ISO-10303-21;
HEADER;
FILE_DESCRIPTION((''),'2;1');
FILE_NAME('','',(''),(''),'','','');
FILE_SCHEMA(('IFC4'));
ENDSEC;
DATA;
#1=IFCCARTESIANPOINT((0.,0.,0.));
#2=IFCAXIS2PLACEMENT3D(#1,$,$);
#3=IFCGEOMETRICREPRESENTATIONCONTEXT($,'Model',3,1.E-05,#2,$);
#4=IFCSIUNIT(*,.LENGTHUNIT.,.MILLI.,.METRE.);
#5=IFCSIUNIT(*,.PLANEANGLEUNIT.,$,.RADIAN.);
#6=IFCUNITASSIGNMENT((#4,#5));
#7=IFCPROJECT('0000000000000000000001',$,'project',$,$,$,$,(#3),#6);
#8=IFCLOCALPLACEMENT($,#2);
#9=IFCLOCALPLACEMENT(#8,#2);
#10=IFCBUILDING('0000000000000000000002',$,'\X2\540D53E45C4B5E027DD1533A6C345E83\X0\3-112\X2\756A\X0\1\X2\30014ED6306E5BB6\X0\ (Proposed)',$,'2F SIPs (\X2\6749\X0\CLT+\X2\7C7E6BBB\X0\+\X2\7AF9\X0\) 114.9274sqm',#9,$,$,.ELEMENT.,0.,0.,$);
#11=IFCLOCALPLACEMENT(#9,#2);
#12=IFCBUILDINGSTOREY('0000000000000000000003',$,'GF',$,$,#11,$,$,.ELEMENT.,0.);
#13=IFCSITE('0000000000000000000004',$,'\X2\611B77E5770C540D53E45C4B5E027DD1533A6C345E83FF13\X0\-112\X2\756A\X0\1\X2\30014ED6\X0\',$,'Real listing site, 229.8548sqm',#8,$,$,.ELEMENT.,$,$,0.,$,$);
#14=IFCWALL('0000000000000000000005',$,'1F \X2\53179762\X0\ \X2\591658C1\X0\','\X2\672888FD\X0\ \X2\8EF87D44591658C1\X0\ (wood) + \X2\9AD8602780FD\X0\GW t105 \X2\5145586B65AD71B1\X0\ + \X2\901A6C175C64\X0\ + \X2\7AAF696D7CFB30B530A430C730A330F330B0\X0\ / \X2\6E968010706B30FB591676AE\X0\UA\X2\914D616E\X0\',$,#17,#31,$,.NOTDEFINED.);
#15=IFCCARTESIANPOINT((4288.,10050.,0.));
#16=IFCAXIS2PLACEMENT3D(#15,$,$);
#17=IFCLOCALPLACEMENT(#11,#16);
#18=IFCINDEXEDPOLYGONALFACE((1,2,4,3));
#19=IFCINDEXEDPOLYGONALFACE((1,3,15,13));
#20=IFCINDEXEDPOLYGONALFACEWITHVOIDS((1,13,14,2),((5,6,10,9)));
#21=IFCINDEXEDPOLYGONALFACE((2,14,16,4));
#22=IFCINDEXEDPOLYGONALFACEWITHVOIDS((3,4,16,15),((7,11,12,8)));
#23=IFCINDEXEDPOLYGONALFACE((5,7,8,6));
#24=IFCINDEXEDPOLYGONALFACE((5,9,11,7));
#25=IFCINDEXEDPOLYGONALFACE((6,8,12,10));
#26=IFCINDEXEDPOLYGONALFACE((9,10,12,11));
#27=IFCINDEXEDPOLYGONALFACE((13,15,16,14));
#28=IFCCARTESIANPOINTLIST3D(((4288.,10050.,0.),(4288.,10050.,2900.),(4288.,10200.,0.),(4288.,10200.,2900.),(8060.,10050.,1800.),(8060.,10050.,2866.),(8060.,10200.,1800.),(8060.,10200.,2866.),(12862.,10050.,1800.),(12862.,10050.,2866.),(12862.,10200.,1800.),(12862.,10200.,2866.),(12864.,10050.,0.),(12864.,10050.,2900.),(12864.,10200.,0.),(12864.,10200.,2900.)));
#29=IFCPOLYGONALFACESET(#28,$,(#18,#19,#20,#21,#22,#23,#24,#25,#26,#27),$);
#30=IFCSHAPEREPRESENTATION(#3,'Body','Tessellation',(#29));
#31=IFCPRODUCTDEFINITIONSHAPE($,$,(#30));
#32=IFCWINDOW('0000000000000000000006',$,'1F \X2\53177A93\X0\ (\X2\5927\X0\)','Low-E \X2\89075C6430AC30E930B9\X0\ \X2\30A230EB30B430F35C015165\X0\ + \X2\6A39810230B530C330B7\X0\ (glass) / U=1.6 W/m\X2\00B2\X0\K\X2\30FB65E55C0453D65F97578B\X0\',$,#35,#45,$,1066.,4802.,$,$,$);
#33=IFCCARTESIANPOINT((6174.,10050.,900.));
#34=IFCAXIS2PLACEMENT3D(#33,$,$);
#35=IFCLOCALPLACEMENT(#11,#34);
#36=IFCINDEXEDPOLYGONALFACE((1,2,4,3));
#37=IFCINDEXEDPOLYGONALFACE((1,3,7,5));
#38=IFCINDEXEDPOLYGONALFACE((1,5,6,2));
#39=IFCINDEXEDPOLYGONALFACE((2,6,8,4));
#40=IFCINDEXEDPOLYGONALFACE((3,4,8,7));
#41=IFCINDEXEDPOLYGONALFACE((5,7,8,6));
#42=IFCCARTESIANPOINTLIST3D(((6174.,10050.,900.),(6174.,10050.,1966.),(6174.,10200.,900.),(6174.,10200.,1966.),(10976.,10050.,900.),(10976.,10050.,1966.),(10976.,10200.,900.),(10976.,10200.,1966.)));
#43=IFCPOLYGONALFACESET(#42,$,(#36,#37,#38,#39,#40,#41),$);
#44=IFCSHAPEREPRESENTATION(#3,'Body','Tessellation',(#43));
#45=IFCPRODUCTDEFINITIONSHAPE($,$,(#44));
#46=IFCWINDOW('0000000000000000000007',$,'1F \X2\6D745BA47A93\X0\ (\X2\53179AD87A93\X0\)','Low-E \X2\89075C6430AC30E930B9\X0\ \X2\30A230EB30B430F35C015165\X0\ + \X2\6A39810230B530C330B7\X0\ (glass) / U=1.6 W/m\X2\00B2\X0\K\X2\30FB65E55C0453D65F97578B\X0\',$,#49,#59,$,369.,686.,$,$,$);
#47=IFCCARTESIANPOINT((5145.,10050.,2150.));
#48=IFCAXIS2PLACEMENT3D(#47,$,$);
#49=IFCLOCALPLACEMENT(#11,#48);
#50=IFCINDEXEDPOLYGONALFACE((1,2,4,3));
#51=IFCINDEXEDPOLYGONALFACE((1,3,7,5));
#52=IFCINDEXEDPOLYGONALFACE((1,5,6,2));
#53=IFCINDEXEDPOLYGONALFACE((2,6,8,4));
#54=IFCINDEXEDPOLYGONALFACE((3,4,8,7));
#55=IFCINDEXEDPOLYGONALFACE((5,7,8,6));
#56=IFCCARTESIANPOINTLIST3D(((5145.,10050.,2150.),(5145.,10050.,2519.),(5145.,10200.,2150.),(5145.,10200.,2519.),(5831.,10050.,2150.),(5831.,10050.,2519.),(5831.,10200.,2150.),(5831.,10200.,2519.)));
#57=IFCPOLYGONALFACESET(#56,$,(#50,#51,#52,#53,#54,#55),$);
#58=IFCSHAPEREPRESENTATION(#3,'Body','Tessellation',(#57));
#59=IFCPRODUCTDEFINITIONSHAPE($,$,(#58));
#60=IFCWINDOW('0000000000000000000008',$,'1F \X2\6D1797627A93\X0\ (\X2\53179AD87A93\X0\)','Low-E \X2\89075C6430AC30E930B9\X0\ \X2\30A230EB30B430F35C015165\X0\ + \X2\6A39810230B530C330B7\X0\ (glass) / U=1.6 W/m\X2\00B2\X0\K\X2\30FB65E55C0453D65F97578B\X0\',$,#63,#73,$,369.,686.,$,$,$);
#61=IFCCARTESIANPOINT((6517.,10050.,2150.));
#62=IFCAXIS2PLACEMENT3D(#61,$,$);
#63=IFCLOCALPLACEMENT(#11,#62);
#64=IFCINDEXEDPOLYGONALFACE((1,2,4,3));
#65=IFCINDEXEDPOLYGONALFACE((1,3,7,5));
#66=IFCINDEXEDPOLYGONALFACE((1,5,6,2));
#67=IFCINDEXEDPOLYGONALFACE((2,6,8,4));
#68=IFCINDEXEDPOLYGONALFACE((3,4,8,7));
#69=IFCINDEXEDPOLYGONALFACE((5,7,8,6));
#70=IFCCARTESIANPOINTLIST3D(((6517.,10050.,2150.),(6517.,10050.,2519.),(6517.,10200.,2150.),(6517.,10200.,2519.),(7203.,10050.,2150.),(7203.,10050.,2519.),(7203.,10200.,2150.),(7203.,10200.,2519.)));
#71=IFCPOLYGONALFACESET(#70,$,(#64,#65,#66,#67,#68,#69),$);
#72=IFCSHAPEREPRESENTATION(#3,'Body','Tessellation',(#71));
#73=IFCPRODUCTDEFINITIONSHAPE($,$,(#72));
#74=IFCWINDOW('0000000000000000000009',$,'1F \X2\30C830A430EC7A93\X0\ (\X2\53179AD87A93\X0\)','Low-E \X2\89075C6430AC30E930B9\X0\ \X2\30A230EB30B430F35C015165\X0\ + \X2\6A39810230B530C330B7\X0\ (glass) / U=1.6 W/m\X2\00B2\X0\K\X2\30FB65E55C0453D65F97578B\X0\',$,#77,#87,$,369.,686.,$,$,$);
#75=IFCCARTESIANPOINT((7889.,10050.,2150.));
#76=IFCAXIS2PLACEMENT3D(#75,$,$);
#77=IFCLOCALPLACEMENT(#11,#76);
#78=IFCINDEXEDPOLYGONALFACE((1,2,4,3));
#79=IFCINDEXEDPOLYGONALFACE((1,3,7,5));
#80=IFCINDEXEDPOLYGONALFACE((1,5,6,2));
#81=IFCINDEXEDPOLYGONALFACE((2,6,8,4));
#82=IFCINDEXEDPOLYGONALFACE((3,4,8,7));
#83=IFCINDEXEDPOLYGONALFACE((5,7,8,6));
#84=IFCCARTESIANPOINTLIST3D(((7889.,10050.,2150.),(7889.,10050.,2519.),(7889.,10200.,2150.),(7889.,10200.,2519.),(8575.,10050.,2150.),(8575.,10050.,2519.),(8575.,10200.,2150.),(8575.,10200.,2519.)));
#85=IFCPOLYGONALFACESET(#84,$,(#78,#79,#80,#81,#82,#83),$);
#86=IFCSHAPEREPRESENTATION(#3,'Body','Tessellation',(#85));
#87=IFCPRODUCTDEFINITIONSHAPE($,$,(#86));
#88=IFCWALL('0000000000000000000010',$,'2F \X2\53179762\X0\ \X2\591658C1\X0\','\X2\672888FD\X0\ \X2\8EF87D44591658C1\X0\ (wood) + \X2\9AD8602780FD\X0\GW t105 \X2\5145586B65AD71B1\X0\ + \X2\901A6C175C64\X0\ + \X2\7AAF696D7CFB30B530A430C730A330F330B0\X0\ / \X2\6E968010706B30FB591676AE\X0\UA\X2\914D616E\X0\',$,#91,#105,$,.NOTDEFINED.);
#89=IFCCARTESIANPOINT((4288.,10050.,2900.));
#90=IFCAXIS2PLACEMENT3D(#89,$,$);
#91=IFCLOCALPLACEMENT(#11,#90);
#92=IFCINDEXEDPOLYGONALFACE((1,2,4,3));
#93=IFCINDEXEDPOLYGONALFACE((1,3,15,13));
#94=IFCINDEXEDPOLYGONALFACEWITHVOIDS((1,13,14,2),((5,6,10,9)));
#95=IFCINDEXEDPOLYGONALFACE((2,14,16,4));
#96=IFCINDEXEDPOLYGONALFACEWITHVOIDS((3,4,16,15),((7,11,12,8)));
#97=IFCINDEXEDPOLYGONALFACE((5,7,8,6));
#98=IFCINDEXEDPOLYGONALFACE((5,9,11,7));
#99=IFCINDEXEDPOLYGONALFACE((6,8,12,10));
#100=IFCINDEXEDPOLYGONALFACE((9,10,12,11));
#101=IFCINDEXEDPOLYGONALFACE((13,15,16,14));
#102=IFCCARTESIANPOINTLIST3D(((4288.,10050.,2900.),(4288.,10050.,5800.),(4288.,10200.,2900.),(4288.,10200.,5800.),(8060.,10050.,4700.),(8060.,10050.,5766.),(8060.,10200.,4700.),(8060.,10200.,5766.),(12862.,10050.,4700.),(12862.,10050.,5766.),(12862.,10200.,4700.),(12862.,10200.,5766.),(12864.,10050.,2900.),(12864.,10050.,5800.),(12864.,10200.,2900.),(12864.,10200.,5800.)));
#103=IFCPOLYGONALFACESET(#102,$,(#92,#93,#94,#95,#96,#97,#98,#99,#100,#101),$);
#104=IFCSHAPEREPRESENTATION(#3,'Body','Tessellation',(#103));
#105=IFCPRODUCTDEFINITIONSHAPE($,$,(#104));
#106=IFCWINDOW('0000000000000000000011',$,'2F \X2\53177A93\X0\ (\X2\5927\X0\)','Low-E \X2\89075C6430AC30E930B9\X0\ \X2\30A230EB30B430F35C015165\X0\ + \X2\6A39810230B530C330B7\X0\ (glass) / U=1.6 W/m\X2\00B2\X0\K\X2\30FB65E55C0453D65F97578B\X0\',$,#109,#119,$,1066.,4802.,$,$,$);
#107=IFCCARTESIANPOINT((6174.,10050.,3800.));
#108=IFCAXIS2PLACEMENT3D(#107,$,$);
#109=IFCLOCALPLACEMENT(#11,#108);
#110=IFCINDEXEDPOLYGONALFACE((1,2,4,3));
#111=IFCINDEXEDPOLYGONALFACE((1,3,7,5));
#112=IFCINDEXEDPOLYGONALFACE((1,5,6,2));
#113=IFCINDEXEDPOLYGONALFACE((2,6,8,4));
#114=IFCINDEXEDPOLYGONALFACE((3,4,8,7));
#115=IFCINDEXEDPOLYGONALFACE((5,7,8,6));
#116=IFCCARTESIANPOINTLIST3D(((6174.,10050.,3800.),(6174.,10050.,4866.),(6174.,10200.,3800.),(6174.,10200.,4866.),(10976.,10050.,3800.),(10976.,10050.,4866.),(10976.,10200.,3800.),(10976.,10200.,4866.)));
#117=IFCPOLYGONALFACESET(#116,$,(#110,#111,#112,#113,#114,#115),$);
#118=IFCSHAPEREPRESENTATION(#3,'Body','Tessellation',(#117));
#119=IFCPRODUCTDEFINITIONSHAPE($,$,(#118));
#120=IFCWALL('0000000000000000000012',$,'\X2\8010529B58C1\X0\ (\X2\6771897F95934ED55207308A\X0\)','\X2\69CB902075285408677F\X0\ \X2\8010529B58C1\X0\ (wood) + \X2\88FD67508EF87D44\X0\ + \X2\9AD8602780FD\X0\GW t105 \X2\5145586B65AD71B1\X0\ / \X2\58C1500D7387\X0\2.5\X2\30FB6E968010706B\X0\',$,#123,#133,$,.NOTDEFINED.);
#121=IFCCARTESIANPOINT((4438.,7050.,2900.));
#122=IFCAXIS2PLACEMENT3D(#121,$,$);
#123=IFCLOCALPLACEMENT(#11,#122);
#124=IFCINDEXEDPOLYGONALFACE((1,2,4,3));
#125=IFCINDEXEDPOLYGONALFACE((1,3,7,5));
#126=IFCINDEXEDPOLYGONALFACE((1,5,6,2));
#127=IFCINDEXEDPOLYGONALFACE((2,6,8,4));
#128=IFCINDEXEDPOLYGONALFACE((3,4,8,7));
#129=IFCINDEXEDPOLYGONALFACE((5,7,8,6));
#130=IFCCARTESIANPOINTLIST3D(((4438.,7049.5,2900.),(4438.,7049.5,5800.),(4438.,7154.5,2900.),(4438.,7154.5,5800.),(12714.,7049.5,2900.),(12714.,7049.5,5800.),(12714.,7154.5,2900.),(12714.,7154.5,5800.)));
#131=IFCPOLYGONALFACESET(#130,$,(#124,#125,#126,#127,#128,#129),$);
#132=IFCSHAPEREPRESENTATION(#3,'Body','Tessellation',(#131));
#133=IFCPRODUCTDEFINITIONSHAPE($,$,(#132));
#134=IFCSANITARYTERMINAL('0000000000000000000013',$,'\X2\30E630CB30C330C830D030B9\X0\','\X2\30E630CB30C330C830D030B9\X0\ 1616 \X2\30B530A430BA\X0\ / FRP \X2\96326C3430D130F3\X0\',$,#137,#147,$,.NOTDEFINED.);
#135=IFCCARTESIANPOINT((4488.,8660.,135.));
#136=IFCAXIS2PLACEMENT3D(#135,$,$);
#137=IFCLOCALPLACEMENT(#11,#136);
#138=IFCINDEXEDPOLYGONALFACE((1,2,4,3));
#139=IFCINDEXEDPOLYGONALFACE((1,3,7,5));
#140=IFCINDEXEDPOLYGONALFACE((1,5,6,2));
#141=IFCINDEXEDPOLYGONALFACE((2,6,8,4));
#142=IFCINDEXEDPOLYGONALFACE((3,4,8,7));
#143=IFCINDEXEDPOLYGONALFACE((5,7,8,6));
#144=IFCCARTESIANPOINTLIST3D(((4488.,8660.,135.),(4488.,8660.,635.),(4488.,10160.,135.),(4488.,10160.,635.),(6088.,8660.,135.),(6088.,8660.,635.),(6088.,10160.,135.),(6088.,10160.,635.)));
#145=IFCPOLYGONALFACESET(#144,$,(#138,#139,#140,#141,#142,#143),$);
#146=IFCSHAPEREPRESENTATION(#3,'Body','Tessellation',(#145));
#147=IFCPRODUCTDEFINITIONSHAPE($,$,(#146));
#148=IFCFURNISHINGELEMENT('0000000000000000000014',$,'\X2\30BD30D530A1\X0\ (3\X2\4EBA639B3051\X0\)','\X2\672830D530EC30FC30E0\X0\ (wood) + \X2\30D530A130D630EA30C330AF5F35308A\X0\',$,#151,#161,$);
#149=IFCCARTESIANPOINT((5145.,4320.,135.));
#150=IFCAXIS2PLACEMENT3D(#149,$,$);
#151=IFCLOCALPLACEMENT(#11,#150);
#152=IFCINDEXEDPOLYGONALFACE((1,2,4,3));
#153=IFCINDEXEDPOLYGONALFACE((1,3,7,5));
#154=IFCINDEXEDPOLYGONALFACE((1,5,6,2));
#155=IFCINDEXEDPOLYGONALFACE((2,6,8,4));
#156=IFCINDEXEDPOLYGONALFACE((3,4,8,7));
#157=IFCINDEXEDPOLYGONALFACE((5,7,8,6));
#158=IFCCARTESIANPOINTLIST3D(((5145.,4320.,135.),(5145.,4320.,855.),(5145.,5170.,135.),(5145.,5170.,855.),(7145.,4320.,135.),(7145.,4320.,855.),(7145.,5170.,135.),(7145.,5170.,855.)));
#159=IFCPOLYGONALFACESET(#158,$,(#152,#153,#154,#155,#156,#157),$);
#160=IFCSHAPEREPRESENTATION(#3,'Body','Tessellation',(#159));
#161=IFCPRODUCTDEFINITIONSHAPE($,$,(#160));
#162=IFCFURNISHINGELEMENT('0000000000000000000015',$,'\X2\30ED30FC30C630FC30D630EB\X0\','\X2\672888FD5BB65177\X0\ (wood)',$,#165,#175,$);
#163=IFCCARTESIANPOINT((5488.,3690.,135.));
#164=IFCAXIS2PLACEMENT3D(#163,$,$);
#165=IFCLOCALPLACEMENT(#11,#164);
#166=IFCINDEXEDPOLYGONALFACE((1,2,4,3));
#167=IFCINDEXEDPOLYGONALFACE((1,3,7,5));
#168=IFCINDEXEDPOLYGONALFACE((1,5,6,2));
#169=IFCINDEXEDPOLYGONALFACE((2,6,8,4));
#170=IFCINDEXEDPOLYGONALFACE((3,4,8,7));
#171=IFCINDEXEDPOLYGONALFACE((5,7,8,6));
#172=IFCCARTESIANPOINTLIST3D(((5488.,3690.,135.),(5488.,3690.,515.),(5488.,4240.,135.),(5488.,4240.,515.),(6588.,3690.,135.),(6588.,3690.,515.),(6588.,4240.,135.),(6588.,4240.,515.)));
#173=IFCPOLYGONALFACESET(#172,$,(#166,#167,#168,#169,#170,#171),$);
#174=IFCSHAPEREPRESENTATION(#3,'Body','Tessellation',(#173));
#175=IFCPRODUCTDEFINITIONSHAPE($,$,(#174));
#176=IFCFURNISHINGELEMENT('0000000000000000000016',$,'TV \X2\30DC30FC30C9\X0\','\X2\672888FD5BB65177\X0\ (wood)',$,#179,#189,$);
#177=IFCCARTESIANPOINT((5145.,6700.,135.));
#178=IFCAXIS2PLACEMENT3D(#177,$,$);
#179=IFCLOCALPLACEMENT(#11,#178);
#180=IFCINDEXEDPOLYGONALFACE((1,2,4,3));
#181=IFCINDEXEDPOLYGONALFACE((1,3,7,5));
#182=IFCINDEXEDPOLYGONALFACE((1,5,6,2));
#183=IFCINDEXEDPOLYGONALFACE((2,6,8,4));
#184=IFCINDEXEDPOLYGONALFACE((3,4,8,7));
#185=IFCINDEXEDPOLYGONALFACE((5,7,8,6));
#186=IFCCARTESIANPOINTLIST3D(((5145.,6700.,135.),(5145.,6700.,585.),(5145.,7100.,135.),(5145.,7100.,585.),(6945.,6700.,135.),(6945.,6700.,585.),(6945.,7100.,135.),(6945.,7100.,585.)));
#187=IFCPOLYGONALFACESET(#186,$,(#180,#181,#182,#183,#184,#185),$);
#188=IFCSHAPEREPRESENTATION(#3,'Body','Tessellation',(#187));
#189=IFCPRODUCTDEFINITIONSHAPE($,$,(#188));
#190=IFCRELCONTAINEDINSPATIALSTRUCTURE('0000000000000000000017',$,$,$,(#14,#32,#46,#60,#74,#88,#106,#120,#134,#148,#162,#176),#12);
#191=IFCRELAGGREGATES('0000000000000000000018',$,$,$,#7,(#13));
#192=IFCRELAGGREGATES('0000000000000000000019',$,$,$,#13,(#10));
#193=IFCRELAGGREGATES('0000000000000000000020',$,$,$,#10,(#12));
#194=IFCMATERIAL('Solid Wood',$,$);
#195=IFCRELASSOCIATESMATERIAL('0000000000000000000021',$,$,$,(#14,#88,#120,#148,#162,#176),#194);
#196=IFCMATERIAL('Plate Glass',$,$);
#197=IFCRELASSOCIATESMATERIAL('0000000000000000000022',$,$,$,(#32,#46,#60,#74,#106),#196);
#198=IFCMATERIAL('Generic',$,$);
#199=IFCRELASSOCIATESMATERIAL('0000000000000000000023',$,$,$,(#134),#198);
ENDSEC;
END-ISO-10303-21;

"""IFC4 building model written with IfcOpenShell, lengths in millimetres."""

from ifc_helpers import new_model, si_unit, frame, frame_2d, origin, place, context, project, spatial, rectangle, extrude, material, element, fill, save


model = new_model("IFC4")

# Units and contexts
model_context = context("Model", 3, precision=1e-05, world=origin())
ifc_project = project(units=[si_unit("LENGTHUNIT", "METRE", prefix="MILLI"), si_unit("PLANEANGLEUNIT", "RADIAN")], contexts=[model_context])

# Site, building, storey
site_placement = place(None, origin())
site = spatial("IfcSite", under=ifc_project, at=site_placement, Name="愛知県名古屋市緑区水広３-112番1、他", ObjectType="Real listing site, 229.8548sqm", CompositionType="ELEMENT", RefElevation=0.0)
building_placement = place(site_placement, origin())
building = spatial("IfcBuilding", under=site, at=building_placement, Name="名古屋市緑区水広3-112番1、他の家 (Proposed)", ObjectType="2F SIPs (杉CLT+籾殻+竹) 114.9274sqm", CompositionType="ELEMENT", ElevationOfRefHeight=0.0, ElevationOfTerrain=0.0)
storey_placement = place(building_placement, origin())
storey = spatial("IfcBuildingStorey", under=building, at=storey_placement, Name="GF", CompositionType="ELEMENT", Elevation=0.0)

# Wall, openings, windows
ifc_material_1 = material(Name="Solid Wood")
wall_1_placement = place(storey_placement, frame((4288.0, 10050.0, 0.0)))
wall_1 = element("IfcWall", 1, at=wall_1_placement, inside=storey, material=ifc_material_1, Name="1F 北面 外壁", Description="木製 軸組外壁 (wood) + 高性能GW t105 充填断熱 + 通気層 + 窯業系サイディング / 準耐火・外皮UA配慮", PredefinedType="NOTDEFINED", context=model_context, shape_type="SweptSolid", body=[
    extrude(rectangle(XDim=8576.0, YDim=150.0, at=frame_2d((4288.0, 75.0))), frame((4288.0, 10050.0, 0.0)), (0.0, 0.0, 1.0), 2900.0),
])
opening_1_placement = place(storey_placement, frame((6174.0, 10050.0, 900.0)))
opening_1 = element("IfcOpeningElement", 2, at=opening_1_placement, cuts=wall_1, PredefinedType="NOTDEFINED", context=model_context, shape_type="SweptSolid", body=[
    extrude(rectangle(XDim=4802.0, YDim=150.0, at=frame_2d((2401.0, 75.0))), frame((6174.0, 10050.0, 900.0)), (0.0, 0.0, 1.0), 1066.0),
])
opening_2_placement = place(storey_placement, frame((5145.0, 10050.0, 2150.0)))
opening_2 = element("IfcOpeningElement", 3, at=opening_2_placement, cuts=wall_1, PredefinedType="NOTDEFINED", context=model_context, shape_type="SweptSolid", body=[
    extrude(rectangle(XDim=686.0, YDim=150.0, at=frame_2d((343.0, 75.0))), frame((5145.0, 10050.0, 2150.0)), (0.0, 0.0, 1.0), 369.0),
])
opening_3_placement = place(storey_placement, frame((6517.0, 10050.0, 2150.0)))
opening_3 = element("IfcOpeningElement", 4, at=opening_3_placement, cuts=wall_1, PredefinedType="NOTDEFINED", context=model_context, shape_type="SweptSolid", body=[
    extrude(rectangle(XDim=686.0, YDim=150.0, at=frame_2d((343.0, 75.0))), frame((6517.0, 10050.0, 2150.0)), (0.0, 0.0, 1.0), 369.0),
])
opening_4_placement = place(storey_placement, frame((7889.0, 10050.0, 2150.0)))
opening_4 = element("IfcOpeningElement", 5, at=opening_4_placement, cuts=wall_1, PredefinedType="NOTDEFINED", context=model_context, shape_type="SweptSolid", body=[
    extrude(rectangle(XDim=686.0, YDim=150.0, at=frame_2d((343.0, 75.0))), frame((7889.0, 10050.0, 2150.0)), (0.0, 0.0, 1.0), 369.0),
])
ifc_material_2 = material(Name="Plate Glass")
window_1_placement = place(storey_placement, frame((6174.0, 10050.0, 900.0)))
window_1 = element("IfcWindow", 6, at=window_1_placement, inside=storey, material=ifc_material_2, Name="1F 北窓 (大)", Description="Low-E 複層ガラス アルゴン封入 + 樹脂サッシ (glass) / U=1.6 W/m²K・日射取得型", OverallHeight=1066.0, OverallWidth=4802.0, context=model_context, shape_type="SweptSolid", body=[
    extrude(rectangle(XDim=4802.0, YDim=150.0, at=frame_2d((2401.0, 75.0))), frame((6174.0, 10050.0, 900.0)), (0.0, 0.0, 1.0), 1066.0),
])
fill(opening_1, window_1)
window_2_placement = place(storey_placement, frame((5145.0, 10050.0, 2150.0)))
window_2 = element("IfcWindow", 7, at=window_2_placement, inside=storey, material=ifc_material_2, Name="1F 浴室窓 (北高窓)", Description="Low-E 複層ガラス アルゴン封入 + 樹脂サッシ (glass) / U=1.6 W/m²K・日射取得型", OverallHeight=369.0, OverallWidth=686.0, context=model_context, shape_type="SweptSolid", body=[
    extrude(rectangle(XDim=686.0, YDim=150.0, at=frame_2d((343.0, 75.0))), frame((5145.0, 10050.0, 2150.0)), (0.0, 0.0, 1.0), 369.0),
])
fill(opening_2, window_2)
window_3_placement = place(storey_placement, frame((6517.0, 10050.0, 2150.0)))
window_3 = element("IfcWindow", 8, at=window_3_placement, inside=storey, material=ifc_material_2, Name="1F 洗面窓 (北高窓)", Description="Low-E 複層ガラス アルゴン封入 + 樹脂サッシ (glass) / U=1.6 W/m²K・日射取得型", OverallHeight=369.0, OverallWidth=686.0, context=model_context, shape_type="SweptSolid", body=[
    extrude(rectangle(XDim=686.0, YDim=150.0, at=frame_2d((343.0, 75.0))), frame((6517.0, 10050.0, 2150.0)), (0.0, 0.0, 1.0), 369.0),
])
fill(opening_3, window_3)
window_4_placement = place(storey_placement, frame((7889.0, 10050.0, 2150.0)))
window_4 = element("IfcWindow", 9, at=window_4_placement, inside=storey, material=ifc_material_2, Name="1F トイレ窓 (北高窓)", Description="Low-E 複層ガラス アルゴン封入 + 樹脂サッシ (glass) / U=1.6 W/m²K・日射取得型", OverallHeight=369.0, OverallWidth=686.0, context=model_context, shape_type="SweptSolid", body=[
    extrude(rectangle(XDim=686.0, YDim=150.0, at=frame_2d((343.0, 75.0))), frame((7889.0, 10050.0, 2150.0)), (0.0, 0.0, 1.0), 369.0),
])
fill(opening_4, window_4)

# Wall, opening, window
wall_2_placement = place(storey_placement, frame((4288.0, 10050.0, 2900.0)))
wall_2 = element("IfcWall", 10, at=wall_2_placement, inside=storey, material=ifc_material_1, Name="2F 北面 外壁", Description="木製 軸組外壁 (wood) + 高性能GW t105 充填断熱 + 通気層 + 窯業系サイディング / 準耐火・外皮UA配慮", PredefinedType="NOTDEFINED", context=model_context, shape_type="SweptSolid", body=[
    extrude(rectangle(XDim=8576.0, YDim=150.0, at=frame_2d((4288.0, 75.0))), frame((4288.0, 10050.0, 2900.0)), (0.0, 0.0, 1.0), 2900.0),
])
opening_5_placement = place(storey_placement, frame((6174.0, 10050.0, 3800.0)))
opening_5 = element("IfcOpeningElement", 11, at=opening_5_placement, cuts=wall_2, PredefinedType="NOTDEFINED", context=model_context, shape_type="SweptSolid", body=[
    extrude(rectangle(XDim=4802.0, YDim=150.0, at=frame_2d((2401.0, 75.0))), frame((6174.0, 10050.0, 3800.0)), (0.0, 0.0, 1.0), 1066.0),
])
window_5_placement = place(storey_placement, frame((6174.0, 10050.0, 3800.0)))
window_5 = element("IfcWindow", 12, at=window_5_placement, inside=storey, material=ifc_material_2, Name="2F 北窓 (大)", Description="Low-E 複層ガラス アルゴン封入 + 樹脂サッシ (glass) / U=1.6 W/m²K・日射取得型", OverallHeight=1066.0, OverallWidth=4802.0, context=model_context, shape_type="SweptSolid", body=[
    extrude(rectangle(XDim=4802.0, YDim=150.0, at=frame_2d((2401.0, 75.0))), frame((6174.0, 10050.0, 3800.0)), (0.0, 0.0, 1.0), 1066.0),
])
fill(opening_5, window_5)

# Wall
wall_3_placement = place(storey_placement, frame((4438.0, 7050.0, 2900.0)))
element("IfcWall", 13, at=wall_3_placement, inside=storey, material=ifc_material_1, Name="耐力壁 (東西間仕切り)", Description="構造用合板 耐力壁 (wood) + 製材軸組 + 高性能GW t105 充填断熱 / 壁倍率2.5・準耐火", PredefinedType="NOTDEFINED", context=model_context, shape_type="SweptSolid", body=[
    extrude(rectangle(XDim=8276.0, YDim=105.0, at=frame_2d((4138.0, 52.0))), frame((4438.0, 7050.0, 2900.0)), (0.0, 0.0, 1.0), 2900.0),
])

# Sanitary terminal
ifc_material_3 = material(Name="Generic")
sanitary_terminal_placement = place(storey_placement, frame((4488.0, 8660.0, 135.0)))
element("IfcSanitaryTerminal", 14, at=sanitary_terminal_placement, inside=storey, material=ifc_material_3, Name="ユニットバス", Description="ユニットバス 1616 サイズ / FRP 防水パン", PredefinedType="NOTDEFINED", context=model_context, shape_type="SweptSolid", body=[
    extrude(rectangle(XDim=1600.0, YDim=1500.0, at=frame_2d((800.0, 750.0))), frame((4488.0, 8660.0, 135.0)), (0.0, 0.0, 1.0), 500.0),
])

# Furnishing elements
furnishing_1_placement = place(storey_placement, frame((5145.0, 4320.0, 135.0)))
element("IfcFurnishingElement", 15, at=furnishing_1_placement, inside=storey, material=ifc_material_1, Name="ソファ (3人掛け)", Description="木フレーム (wood) + ファブリック張り", context=model_context, shape_type="SweptSolid", body=[
    extrude(rectangle(XDim=2000.0, YDim=850.0, at=frame_2d((1000.0, 425.0))), frame((5145.0, 4320.0, 135.0)), (0.0, 0.0, 1.0), 720.0),
])
furnishing_2_placement = place(storey_placement, frame((5488.0, 3690.0, 135.0)))
element("IfcFurnishingElement", 16, at=furnishing_2_placement, inside=storey, material=ifc_material_1, Name="ローテーブル", Description="木製家具 (wood)", context=model_context, shape_type="SweptSolid", body=[
    extrude(rectangle(XDim=1100.0, YDim=550.0, at=frame_2d((550.0, 275.0))), frame((5488.0, 3690.0, 135.0)), (0.0, 0.0, 1.0), 380.0),
])
furnishing_3_placement = place(storey_placement, frame((5145.0, 6700.0, 135.0)))
element("IfcFurnishingElement", 17, at=furnishing_3_placement, inside=storey, material=ifc_material_1, Name="TV ボード", Description="木製家具 (wood)", context=model_context, shape_type="SweptSolid", body=[
    extrude(rectangle(XDim=1800.0, YDim=400.0, at=frame_2d((900.0, 200.0))), frame((5145.0, 6700.0, 135.0)), (0.0, 0.0, 1.0), 450.0),
])

save(model, "model.ifc")
